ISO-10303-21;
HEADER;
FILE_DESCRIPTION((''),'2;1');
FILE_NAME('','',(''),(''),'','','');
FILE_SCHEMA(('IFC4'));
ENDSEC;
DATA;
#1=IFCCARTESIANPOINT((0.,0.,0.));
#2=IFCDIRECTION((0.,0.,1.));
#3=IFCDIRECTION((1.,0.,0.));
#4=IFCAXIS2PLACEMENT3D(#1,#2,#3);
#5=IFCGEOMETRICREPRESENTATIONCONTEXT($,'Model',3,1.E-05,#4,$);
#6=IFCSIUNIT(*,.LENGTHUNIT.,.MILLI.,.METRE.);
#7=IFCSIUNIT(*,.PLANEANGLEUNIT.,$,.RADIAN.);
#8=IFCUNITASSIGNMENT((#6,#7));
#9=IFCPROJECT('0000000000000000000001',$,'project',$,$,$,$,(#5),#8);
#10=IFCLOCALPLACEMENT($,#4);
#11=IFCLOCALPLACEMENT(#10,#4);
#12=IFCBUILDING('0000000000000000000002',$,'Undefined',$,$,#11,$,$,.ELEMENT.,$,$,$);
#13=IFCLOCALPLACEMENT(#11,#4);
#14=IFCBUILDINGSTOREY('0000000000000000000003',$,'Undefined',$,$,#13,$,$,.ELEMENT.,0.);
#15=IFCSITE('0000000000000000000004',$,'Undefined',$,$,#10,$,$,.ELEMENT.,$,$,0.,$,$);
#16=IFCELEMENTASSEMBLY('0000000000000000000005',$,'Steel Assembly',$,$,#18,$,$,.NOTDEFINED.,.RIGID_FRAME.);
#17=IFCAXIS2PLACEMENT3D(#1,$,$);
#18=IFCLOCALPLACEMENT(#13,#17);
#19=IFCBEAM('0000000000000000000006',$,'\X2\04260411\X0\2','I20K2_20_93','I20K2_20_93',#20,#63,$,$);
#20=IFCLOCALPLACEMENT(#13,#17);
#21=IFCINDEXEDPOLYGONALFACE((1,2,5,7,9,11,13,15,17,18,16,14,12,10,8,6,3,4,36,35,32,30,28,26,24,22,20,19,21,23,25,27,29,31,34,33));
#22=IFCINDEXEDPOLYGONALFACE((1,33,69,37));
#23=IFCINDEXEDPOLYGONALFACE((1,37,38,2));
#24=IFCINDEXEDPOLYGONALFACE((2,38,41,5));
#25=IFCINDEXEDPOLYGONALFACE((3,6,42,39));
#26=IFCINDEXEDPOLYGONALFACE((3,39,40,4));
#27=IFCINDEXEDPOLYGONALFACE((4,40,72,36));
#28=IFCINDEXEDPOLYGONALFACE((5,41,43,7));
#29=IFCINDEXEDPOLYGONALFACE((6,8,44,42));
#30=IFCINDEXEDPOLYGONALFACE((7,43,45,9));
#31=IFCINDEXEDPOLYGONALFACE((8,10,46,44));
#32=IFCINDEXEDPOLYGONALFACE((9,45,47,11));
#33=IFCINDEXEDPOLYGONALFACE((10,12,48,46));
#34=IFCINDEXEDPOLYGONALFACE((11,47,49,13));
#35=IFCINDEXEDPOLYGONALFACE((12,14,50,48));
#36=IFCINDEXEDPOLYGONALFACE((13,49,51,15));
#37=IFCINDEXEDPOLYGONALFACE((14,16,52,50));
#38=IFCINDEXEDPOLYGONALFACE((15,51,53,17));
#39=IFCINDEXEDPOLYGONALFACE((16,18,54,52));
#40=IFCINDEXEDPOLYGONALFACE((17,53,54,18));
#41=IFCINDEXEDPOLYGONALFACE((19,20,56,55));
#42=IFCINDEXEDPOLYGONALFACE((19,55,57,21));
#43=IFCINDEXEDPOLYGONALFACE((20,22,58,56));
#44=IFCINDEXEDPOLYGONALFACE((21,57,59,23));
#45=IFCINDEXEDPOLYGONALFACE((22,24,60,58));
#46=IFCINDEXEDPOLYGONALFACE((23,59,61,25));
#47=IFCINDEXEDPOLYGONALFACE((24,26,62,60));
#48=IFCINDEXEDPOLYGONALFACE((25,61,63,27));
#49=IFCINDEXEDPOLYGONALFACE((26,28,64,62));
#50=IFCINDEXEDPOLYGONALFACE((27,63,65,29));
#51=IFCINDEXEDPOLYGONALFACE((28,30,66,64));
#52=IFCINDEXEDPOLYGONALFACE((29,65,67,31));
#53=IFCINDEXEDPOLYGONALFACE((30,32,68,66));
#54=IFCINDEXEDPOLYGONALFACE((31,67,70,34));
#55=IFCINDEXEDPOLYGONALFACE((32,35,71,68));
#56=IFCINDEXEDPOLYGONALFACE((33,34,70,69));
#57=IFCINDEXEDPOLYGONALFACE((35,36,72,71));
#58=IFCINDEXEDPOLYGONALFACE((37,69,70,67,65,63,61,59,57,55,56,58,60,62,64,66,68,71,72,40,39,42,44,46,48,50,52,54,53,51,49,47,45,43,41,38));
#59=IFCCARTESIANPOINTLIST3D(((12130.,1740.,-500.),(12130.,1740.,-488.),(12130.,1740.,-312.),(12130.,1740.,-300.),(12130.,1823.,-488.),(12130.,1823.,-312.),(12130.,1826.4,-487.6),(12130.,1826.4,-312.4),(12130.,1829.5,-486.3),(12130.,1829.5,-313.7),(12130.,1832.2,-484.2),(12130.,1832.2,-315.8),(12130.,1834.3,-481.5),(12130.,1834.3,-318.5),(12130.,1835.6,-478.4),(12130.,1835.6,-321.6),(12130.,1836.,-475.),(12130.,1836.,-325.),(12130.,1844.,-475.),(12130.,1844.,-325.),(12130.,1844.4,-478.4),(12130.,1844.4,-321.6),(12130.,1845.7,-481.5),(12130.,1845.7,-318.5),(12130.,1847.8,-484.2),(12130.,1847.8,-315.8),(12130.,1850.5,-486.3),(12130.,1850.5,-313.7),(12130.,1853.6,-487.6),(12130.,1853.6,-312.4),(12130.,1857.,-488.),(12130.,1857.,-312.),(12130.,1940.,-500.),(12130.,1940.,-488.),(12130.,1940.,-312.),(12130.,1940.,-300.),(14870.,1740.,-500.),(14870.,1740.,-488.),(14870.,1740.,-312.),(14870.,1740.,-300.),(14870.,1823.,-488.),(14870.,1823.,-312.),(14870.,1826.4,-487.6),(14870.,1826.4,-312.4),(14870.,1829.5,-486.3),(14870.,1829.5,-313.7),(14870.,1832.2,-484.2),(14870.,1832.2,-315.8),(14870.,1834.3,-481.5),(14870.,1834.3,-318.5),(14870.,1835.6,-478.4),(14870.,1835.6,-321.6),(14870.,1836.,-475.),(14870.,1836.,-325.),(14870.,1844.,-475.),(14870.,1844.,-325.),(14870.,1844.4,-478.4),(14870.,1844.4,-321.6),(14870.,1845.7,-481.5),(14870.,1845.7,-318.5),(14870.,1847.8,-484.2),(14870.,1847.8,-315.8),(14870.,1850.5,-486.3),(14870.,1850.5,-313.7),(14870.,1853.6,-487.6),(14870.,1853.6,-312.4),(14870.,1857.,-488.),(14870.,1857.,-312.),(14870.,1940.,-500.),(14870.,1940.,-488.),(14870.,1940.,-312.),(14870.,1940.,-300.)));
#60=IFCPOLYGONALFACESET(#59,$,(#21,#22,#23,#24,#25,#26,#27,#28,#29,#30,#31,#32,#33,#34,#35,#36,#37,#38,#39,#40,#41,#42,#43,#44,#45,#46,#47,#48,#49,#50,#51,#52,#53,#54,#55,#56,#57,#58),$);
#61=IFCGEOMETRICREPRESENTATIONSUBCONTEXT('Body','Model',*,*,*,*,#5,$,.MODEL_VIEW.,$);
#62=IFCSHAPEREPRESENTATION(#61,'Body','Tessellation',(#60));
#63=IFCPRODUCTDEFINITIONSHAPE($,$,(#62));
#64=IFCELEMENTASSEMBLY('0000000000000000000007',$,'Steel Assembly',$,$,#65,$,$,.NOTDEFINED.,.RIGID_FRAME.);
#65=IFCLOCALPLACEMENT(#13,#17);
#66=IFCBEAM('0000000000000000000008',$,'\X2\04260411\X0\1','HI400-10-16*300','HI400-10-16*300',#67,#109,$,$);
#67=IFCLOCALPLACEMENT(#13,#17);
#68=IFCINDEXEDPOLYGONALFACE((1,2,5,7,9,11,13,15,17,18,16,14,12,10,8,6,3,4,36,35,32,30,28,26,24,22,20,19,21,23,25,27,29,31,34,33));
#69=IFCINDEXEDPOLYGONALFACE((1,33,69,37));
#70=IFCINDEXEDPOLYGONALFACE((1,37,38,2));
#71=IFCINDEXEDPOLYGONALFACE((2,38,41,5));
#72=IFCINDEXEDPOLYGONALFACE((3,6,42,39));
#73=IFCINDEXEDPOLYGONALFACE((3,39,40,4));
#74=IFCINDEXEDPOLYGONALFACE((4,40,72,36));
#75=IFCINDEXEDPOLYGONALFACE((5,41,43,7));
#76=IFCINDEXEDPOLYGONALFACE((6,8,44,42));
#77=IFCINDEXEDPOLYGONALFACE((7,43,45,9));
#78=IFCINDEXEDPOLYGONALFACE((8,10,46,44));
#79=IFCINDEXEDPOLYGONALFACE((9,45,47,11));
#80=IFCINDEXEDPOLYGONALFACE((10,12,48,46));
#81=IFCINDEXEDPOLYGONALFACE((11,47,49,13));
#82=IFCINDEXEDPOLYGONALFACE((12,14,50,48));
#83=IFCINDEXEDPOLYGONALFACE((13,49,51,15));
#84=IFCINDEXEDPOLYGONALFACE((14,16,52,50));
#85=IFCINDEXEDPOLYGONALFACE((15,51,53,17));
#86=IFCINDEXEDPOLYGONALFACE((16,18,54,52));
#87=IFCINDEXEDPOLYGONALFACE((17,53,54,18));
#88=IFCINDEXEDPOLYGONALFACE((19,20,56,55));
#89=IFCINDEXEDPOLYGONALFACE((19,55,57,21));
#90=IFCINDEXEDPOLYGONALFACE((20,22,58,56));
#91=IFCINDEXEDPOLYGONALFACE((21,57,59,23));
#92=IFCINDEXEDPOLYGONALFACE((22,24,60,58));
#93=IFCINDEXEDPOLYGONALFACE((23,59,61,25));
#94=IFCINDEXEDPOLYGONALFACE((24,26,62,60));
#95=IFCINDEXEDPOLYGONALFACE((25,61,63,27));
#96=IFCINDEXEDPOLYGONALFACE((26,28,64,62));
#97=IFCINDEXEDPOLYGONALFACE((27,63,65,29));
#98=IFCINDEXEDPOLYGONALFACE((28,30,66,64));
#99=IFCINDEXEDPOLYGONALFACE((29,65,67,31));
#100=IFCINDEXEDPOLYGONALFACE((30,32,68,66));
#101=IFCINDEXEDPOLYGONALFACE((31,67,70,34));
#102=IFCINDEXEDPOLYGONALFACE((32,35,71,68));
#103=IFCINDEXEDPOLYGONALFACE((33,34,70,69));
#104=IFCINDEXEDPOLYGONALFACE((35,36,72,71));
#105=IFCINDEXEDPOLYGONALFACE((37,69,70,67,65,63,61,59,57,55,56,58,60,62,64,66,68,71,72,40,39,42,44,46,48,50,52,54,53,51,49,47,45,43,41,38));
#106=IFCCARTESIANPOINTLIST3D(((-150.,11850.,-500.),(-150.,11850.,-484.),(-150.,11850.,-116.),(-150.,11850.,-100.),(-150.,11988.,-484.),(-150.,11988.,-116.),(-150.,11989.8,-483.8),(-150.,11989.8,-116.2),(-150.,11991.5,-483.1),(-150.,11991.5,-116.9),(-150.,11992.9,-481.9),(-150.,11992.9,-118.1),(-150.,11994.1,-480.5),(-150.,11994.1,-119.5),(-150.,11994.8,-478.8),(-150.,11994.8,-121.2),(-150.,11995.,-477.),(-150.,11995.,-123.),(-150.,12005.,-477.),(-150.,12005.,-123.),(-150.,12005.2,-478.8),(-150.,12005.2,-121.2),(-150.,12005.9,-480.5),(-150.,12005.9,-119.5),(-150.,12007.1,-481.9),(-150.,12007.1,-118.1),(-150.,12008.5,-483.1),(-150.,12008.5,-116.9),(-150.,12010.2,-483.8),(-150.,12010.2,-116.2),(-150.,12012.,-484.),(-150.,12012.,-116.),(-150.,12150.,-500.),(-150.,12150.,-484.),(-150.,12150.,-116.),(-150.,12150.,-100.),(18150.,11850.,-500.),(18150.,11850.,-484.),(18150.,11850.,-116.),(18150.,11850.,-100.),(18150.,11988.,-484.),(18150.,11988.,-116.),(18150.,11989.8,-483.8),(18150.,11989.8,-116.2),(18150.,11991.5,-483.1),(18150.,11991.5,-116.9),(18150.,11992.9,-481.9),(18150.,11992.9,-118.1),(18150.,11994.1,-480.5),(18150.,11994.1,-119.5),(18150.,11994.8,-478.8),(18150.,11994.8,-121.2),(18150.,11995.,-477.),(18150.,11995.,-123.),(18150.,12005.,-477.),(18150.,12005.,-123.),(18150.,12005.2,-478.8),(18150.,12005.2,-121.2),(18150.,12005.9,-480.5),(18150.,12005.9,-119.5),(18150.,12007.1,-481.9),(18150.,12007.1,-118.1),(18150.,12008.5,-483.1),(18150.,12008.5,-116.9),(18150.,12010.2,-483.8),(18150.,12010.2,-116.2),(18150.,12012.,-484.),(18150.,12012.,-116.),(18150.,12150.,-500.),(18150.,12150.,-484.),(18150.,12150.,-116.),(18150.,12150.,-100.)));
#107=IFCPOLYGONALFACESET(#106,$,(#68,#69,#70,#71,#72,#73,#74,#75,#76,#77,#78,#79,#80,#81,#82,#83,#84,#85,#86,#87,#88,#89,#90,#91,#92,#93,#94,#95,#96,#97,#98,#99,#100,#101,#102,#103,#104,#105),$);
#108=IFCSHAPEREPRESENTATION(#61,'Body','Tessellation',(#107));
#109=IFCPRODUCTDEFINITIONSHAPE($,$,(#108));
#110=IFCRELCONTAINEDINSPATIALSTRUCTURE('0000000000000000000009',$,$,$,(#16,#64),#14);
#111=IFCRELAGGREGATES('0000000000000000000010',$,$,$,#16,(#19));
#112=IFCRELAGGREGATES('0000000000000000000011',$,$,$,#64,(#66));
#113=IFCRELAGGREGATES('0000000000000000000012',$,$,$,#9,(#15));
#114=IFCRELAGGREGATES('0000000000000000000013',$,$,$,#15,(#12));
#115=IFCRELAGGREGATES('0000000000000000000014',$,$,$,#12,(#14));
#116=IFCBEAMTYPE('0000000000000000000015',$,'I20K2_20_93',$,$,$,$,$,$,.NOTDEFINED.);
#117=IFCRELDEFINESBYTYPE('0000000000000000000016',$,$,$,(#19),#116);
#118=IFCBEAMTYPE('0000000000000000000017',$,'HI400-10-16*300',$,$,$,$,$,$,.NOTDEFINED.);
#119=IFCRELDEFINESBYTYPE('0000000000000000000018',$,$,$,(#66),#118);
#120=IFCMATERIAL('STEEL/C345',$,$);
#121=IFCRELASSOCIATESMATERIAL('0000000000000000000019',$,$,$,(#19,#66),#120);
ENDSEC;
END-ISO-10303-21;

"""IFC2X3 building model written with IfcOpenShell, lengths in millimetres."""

from ifc_helpers import new_model, si_unit, frame, origin_with_axes, origin_2d_with_axis, place, context, subcontext, project, spatial, i_section, extrude, material, type_object, element, aggregate, save


model = new_model("IFC2X3")

# Units and contexts
model_context = context("Model", 3, precision=1e-05, world=origin_with_axes())
body_context = subcontext(model_context, "Body", "Model", "MODEL_VIEW")
ifc_project = project(units=[si_unit("LENGTHUNIT", "METRE", prefix="MILLI"), si_unit("PLANEANGLEUNIT", "RADIAN")], contexts=[model_context])

# Site, building, storey
site_placement = place(None, origin_with_axes())
site = spatial("IfcSite", under=ifc_project, at=site_placement, Name="Undefined", CompositionType="ELEMENT", RefElevation=0.0)
building_placement = place(site_placement, origin_with_axes())
building = spatial("IfcBuilding", under=site, at=building_placement, Name="Undefined", CompositionType="ELEMENT")
storey_placement = place(building_placement, origin_with_axes())
storey = spatial("IfcBuildingStorey", under=building, at=storey_placement, Name="Undefined", CompositionType="ELEMENT", Elevation=0.0)

# Shared definitions
ifc_material_1 = material(Name="STEEL/C345")

# Element assemblies, beams
assembly_1_placement = place(storey_placement, origin_with_axes())
assembly_1 = element("IfcElementAssembly", 1, at=assembly_1_placement, inside=storey, Name="Steel Assembly", AssemblyPlace="NOTDEFINED", PredefinedType="RIGID_FRAME")
beam_type_1 = type_object("IfcBeamType", Name="I20K2_20_93", PredefinedType="NOTDEFINED")
beam_1_placement = place(assembly_1_placement, frame((14870.0, 1840.0, -400.0), z_axis=(0.0, 0.0, 1.0), x_axis=(-1.0, 0.0, 0.0)))
beam_1 = element("IfcBeam", 2, at=beam_1_placement, type_object=beam_type_1, material=ifc_material_1, Name="ЦБ2", Description="I20K2_20_93", ObjectType="I20K2_20_93", context=body_context, shape_type="SweptSolid", body=[
    extrude(i_section(OverallWidth=200.0, OverallDepth=200.0, WebThickness=8.0, FlangeThickness=12.0, FilletRadius=13.0, at=origin_2d_with_axis()), frame((2740.0, 0.0, 0.0), z_axis=(-1.0, 0.0, 0.0), x_axis=(0.0, -1.0, 0.0)), (0.0, 0.0, 1.0), 2740.0),
])
aggregate(assembly_1, [beam_1])
assembly_2_placement = place(storey_placement, origin_with_axes())
assembly_2 = element("IfcElementAssembly", 3, at=assembly_2_placement, inside=storey, Name="Steel Assembly", AssemblyPlace="NOTDEFINED", PredefinedType="RIGID_FRAME")
beam_type_2 = type_object("IfcBeamType", Name="HI400-10-16*300", PredefinedType="NOTDEFINED")
beam_2_placement = place(assembly_2_placement, frame((18150.0, 12000.0, -300.0), z_axis=(0.0, 0.0, 1.0), x_axis=(-1.0, 0.0, 0.0)))
beam_2 = element("IfcBeam", 4, at=beam_2_placement, type_object=beam_type_2, material=ifc_material_1, Name="ЦБ1", Description="HI400-10-16*300", ObjectType="HI400-10-16*300", context=body_context, shape_type="SweptSolid", body=[
    extrude(i_section(OverallWidth=300.0, OverallDepth=400.0, WebThickness=10.0, FlangeThickness=16.0, FilletRadius=7.0, at=origin_2d_with_axis()), frame((18300.0, 0.0, 0.0), z_axis=(-1.0, 0.0, 0.0), x_axis=(0.0, -1.0, 0.0)), (0.0, 0.0, 1.0), 18300.0),
])
aggregate(assembly_2, [beam_2])

save(model, "model.ifc")
